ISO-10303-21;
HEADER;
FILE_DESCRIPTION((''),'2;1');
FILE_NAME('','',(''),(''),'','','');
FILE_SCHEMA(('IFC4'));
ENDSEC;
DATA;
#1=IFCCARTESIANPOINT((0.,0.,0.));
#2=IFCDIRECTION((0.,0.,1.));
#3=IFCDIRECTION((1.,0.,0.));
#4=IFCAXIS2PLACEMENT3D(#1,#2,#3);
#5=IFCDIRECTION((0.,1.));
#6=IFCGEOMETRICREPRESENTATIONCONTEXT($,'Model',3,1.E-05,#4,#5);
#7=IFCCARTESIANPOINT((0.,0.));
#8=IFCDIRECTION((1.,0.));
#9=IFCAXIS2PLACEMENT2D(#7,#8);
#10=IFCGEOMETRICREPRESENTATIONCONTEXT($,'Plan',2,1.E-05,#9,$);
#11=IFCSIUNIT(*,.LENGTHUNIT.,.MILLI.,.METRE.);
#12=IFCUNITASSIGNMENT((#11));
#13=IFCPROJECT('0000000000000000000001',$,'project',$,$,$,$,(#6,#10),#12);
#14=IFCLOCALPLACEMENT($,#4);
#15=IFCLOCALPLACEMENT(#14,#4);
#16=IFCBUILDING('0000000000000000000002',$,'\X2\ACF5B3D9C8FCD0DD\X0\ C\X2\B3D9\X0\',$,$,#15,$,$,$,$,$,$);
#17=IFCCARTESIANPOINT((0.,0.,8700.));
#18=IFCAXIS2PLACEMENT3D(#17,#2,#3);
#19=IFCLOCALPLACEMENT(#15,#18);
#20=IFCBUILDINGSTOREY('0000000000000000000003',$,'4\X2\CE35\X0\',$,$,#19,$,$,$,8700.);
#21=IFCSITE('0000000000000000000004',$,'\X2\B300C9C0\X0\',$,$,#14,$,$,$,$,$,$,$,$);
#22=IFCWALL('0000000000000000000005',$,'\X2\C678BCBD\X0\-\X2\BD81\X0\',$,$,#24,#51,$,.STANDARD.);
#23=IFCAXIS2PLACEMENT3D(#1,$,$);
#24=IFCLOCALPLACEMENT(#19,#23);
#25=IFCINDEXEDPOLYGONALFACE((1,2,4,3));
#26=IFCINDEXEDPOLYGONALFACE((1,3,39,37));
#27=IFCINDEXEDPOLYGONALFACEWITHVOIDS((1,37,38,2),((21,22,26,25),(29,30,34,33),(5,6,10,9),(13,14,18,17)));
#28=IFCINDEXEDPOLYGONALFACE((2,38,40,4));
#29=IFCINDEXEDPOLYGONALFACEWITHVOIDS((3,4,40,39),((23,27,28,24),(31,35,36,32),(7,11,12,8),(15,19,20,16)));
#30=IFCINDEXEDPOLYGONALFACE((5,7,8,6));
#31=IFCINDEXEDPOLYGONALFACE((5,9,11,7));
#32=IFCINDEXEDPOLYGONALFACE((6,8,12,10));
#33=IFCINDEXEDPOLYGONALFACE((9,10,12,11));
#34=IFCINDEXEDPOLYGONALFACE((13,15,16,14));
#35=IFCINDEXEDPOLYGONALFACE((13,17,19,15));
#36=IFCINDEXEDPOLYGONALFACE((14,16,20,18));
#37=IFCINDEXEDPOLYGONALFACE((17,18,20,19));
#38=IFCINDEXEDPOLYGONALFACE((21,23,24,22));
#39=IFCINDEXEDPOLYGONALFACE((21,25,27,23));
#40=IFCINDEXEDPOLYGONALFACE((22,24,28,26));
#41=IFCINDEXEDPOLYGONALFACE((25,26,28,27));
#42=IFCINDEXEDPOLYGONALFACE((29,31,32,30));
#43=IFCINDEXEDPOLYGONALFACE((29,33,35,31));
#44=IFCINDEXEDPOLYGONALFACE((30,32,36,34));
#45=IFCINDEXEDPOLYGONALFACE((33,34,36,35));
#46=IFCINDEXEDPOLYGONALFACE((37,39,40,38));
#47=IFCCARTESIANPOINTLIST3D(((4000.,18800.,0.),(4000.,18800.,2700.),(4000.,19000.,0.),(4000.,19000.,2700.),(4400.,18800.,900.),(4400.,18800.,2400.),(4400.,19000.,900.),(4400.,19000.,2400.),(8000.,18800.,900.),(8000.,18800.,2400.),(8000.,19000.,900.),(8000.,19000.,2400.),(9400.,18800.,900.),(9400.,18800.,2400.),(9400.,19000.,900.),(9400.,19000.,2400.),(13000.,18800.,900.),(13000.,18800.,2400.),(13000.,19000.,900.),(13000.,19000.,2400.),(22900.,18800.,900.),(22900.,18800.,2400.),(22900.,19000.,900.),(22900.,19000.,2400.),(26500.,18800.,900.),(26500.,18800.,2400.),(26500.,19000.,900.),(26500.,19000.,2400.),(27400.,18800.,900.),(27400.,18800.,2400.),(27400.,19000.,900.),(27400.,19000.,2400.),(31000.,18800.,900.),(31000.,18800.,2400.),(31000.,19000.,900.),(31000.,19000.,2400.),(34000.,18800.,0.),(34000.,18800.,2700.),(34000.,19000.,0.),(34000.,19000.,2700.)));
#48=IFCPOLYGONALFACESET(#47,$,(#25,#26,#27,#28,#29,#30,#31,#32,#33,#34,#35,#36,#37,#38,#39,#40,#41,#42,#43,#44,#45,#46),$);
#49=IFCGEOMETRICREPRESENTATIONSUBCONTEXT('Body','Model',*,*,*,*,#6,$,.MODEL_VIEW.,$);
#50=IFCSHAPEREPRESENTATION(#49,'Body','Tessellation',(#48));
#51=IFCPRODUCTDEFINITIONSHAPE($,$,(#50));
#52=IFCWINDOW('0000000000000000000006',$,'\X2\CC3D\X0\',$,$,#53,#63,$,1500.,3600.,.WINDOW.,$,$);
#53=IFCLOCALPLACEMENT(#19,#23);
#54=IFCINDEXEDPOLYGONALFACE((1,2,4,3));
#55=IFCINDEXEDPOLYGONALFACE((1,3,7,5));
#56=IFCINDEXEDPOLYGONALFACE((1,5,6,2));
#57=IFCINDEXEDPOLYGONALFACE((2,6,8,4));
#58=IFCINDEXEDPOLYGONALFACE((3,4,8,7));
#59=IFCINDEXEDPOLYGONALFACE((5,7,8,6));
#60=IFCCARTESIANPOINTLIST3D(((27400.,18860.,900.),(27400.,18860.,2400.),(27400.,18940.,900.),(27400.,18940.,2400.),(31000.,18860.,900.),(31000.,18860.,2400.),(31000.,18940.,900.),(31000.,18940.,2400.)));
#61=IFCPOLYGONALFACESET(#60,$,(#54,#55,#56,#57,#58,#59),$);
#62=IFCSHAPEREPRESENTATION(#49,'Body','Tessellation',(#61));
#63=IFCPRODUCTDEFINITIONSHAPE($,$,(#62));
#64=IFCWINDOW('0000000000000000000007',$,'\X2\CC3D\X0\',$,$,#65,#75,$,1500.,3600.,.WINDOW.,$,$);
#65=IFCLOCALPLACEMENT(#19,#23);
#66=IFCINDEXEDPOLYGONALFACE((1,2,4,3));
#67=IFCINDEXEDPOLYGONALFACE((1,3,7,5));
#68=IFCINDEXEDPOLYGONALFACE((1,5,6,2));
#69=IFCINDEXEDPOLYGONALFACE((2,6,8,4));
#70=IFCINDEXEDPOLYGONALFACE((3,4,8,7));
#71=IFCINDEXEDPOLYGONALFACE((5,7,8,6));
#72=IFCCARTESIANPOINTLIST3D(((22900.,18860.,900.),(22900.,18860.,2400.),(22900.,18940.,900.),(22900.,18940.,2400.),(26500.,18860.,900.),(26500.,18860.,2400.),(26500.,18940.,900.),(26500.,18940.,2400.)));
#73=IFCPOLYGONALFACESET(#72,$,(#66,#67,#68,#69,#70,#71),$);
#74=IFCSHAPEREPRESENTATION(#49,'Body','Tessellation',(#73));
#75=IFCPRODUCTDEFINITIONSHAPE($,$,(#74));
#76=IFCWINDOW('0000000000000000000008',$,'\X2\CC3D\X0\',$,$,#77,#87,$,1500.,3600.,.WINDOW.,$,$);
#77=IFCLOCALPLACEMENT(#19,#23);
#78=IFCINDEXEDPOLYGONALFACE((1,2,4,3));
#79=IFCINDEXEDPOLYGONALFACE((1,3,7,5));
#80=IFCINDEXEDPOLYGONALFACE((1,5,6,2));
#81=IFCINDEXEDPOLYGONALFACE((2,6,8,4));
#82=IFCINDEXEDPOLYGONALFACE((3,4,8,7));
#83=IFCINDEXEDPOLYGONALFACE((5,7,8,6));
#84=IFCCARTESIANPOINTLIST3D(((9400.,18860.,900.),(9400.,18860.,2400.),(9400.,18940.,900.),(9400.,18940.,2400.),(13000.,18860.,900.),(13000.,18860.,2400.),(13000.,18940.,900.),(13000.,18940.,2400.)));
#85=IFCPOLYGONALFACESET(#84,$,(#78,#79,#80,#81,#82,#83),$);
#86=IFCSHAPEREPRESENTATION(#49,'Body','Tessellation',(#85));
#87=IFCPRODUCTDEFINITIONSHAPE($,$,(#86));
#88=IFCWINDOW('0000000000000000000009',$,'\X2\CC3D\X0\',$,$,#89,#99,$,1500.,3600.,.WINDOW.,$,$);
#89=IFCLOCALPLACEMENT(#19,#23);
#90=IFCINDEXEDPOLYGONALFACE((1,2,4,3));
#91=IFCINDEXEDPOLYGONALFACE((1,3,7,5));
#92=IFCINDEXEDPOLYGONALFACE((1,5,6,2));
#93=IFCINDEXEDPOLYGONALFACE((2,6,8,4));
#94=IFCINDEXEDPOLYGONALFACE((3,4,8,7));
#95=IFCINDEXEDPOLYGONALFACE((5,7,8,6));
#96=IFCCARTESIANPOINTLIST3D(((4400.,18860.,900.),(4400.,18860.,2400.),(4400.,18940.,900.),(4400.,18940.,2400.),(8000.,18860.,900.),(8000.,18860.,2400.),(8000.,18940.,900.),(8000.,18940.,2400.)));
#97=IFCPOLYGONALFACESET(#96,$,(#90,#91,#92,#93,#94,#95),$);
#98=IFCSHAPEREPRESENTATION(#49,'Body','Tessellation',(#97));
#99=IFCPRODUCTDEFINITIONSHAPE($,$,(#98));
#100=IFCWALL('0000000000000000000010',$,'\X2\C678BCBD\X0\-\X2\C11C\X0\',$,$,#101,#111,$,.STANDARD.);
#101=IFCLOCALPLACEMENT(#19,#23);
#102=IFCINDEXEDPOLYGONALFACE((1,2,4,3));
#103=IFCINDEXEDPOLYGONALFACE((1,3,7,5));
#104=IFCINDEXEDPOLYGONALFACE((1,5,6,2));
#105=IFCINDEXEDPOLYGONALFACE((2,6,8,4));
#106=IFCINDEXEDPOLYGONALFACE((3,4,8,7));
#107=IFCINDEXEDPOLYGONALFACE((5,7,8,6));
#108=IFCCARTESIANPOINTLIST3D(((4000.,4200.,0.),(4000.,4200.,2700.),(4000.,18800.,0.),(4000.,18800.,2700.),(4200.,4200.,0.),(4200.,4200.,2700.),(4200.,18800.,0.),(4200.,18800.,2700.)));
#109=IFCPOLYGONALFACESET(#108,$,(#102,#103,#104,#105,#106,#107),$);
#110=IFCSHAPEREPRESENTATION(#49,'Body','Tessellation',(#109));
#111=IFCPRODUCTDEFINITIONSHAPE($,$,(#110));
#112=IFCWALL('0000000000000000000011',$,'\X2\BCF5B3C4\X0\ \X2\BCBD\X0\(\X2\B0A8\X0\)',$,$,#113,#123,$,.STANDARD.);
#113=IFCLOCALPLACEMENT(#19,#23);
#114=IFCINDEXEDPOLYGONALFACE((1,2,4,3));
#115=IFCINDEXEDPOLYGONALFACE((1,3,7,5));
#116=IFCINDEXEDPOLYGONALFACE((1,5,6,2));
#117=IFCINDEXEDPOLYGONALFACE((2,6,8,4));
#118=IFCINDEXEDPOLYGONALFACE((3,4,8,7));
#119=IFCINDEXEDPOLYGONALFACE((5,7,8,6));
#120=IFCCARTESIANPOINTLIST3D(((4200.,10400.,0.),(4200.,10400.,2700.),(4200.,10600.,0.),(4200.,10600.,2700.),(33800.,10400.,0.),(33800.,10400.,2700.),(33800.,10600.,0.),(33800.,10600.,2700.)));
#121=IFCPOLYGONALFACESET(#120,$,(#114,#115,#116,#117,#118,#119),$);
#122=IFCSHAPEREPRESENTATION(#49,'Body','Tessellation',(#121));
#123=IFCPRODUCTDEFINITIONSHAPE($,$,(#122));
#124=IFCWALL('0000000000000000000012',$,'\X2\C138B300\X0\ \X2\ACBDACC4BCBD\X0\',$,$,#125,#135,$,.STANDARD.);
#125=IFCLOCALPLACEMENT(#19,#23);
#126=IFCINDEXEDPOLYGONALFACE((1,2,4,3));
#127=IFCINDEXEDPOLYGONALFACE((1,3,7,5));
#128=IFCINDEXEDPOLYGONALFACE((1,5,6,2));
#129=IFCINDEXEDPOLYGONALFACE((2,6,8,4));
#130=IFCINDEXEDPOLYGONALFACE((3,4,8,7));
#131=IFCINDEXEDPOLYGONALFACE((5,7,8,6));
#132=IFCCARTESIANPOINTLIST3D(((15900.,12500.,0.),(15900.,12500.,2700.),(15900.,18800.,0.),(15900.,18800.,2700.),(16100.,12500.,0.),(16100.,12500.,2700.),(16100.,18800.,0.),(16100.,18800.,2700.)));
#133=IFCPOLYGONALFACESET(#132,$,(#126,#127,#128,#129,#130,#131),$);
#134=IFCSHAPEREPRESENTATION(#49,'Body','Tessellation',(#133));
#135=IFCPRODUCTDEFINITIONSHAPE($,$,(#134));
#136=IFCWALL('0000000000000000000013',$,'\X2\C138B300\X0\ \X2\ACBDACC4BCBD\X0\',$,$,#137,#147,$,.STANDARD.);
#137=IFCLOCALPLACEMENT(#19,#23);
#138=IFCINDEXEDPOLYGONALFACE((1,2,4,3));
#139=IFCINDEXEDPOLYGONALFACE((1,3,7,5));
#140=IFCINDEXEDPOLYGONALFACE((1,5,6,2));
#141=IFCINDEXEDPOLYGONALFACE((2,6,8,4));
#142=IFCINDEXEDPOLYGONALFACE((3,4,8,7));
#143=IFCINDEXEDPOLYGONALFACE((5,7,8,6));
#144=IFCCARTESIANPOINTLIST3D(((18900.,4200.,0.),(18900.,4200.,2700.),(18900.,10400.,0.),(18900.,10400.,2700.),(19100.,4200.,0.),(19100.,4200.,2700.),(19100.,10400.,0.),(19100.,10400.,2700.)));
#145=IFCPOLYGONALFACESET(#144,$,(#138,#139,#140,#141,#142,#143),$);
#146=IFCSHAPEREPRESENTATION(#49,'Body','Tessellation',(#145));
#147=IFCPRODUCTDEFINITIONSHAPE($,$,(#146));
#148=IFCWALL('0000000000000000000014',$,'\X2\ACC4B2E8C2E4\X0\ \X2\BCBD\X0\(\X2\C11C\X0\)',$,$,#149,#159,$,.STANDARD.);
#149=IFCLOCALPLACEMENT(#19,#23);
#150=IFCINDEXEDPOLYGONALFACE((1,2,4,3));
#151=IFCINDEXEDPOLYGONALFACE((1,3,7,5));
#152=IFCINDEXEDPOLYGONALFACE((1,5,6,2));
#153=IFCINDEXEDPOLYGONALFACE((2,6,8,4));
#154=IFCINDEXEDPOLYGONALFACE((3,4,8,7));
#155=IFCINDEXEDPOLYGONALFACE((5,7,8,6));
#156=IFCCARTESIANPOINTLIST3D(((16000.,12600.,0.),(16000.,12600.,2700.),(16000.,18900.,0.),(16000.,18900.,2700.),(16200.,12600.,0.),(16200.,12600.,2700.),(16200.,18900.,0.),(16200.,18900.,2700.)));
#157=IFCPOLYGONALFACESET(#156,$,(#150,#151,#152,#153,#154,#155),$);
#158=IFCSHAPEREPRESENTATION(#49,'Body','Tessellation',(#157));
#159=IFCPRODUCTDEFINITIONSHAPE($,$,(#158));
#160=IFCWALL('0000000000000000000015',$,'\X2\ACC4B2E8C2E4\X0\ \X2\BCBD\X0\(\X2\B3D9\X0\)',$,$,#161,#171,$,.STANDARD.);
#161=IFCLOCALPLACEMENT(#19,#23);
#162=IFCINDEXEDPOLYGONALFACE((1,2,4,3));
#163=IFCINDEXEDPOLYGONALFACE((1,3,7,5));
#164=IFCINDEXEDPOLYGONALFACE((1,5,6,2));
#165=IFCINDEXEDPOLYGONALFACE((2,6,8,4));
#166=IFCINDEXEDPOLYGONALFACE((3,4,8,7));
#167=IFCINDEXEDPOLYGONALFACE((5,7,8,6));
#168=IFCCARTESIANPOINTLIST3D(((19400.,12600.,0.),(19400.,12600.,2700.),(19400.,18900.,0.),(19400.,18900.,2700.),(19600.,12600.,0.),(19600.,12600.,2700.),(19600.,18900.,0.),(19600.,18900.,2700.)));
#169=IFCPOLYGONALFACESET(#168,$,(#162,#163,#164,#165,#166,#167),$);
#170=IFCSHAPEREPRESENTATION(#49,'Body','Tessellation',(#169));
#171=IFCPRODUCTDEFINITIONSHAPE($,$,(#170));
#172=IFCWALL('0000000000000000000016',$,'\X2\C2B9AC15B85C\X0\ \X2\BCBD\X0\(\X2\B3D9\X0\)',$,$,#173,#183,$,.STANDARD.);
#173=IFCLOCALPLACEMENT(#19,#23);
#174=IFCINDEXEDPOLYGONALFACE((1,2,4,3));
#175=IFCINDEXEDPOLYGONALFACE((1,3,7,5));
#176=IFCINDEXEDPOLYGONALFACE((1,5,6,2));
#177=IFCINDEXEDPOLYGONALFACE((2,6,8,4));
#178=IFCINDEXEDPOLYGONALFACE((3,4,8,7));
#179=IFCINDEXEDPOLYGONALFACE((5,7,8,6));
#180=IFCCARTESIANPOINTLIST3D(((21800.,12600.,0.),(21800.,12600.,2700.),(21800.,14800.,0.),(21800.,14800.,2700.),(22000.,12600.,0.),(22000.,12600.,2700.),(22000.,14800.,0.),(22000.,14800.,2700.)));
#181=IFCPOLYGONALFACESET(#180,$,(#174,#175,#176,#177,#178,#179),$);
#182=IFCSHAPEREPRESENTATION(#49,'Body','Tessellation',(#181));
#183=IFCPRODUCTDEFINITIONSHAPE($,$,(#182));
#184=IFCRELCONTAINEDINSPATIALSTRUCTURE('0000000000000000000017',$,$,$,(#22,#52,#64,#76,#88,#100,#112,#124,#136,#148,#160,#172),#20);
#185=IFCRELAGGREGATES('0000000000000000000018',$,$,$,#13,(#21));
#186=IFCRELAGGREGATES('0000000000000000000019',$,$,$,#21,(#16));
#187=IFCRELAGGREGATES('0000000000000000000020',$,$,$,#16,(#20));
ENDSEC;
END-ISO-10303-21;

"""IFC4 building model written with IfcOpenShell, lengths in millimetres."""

from ifc_helpers import new_model, si_unit, direction, frame, origin_with_axes, origin_2d_with_axis, place, context, subcontext, project, spatial, polyline, outline, extrude, element, fill, save


model = new_model("IFC4")

# Units and contexts
model_context = context("Model", 3, precision=1e-05, world=origin_with_axes(), true_north=direction((0.0, 1.0)))
plan_context = context("Plan", 2, precision=1e-05, world=origin_2d_with_axis())
body_context = subcontext(model_context, "Body", "Model", "MODEL_VIEW")
ifc_project = project(units=[si_unit("LENGTHUNIT", "METRE", prefix="MILLI")], contexts=[model_context, plan_context])

# Site, building, storey
site_placement = place(None, origin_with_axes())
site = spatial("IfcSite", under=ifc_project, at=site_placement, Name="대지")
building_placement = place(site_placement, origin_with_axes())
building = spatial("IfcBuilding", under=site, at=building_placement, Name="공동주택 C동")
storey_placement = place(building_placement, frame((0.0, 0.0, 8700.0), z_axis=(0.0, 0.0, 1.0), x_axis=(1.0, 0.0, 0.0)))
storey = spatial("IfcBuildingStorey", under=building, at=storey_placement, Name="4층", Elevation=8700.0)

# Wall, openings, windows
wall_1_placement = place(storey_placement, origin_with_axes())
wall_1 = element("IfcWall", 1, at=wall_1_placement, inside=storey, Name="외벽-북", PredefinedType="STANDARD", context=body_context, shape_type="SweptSolid", body=[
    extrude(outline(polyline([(34000.0, 18800.0), (4000.0, 18800.0), (4000.0, 19000.0), (34000.0, 19000.0), (34000.0, 18800.0)])), origin_with_axes(), (0.0, 0.0, 1.0), 2700.0),
])
opening_1_placement = place(storey_placement, origin_with_axes())
opening_1 = element("IfcOpeningElement", 2, at=opening_1_placement, cuts=wall_1, PredefinedType="OPENING", context=body_context, shape_type="SweptSolid", body=[
    extrude(outline(polyline([(31000.0, 19050.0), (27400.0, 19050.0), (27400.0, 18750.0), (31000.0, 18750.0), (31000.0, 19050.0)])), frame((0.0, 0.0, 900.0), z_axis=(0.0, 0.0, 1.0), x_axis=(1.0, 0.0, 0.0)), (0.0, 0.0, 1.0), 1500.0),
])
opening_2_placement = place(storey_placement, origin_with_axes())
opening_2 = element("IfcOpeningElement", 3, at=opening_2_placement, cuts=wall_1, PredefinedType="OPENING", context=body_context, shape_type="SweptSolid", body=[
    extrude(outline(polyline([(26500.0, 19050.0), (22900.0, 19050.0), (22900.0, 18750.0), (26500.0, 18750.0), (26500.0, 19050.0)])), frame((0.0, 0.0, 900.0), z_axis=(0.0, 0.0, 1.0), x_axis=(1.0, 0.0, 0.0)), (0.0, 0.0, 1.0), 1500.0),
])
opening_3_placement = place(storey_placement, origin_with_axes())
opening_3 = element("IfcOpeningElement", 4, at=opening_3_placement, cuts=wall_1, PredefinedType="OPENING", context=body_context, shape_type="SweptSolid", body=[
    extrude(outline(polyline([(13000.0, 19050.0), (9400.0, 19050.0), (9400.0, 18750.0), (13000.0, 18750.0), (13000.0, 19050.0)])), frame((0.0, 0.0, 900.0), z_axis=(0.0, 0.0, 1.0), x_axis=(1.0, 0.0, 0.0)), (0.0, 0.0, 1.0), 1500.0),
])
opening_4_placement = place(storey_placement, origin_with_axes())
opening_4 = element("IfcOpeningElement", 5, at=opening_4_placement, cuts=wall_1, PredefinedType="OPENING", context=body_context, shape_type="SweptSolid", body=[
    extrude(outline(polyline([(8000.0, 19050.0), (4400.0, 19050.0), (4400.0, 18750.0), (8000.0, 18750.0), (8000.0, 19050.0)])), frame((0.0, 0.0, 900.0), z_axis=(0.0, 0.0, 1.0), x_axis=(1.0, 0.0, 0.0)), (0.0, 0.0, 1.0), 1500.0),
])
window_1_placement = place(storey_placement, origin_with_axes())
window_1 = element("IfcWindow", 6, at=window_1_placement, inside=storey, Name="창", OverallHeight=1500.0, OverallWidth=3600.0, PredefinedType="WINDOW", context=body_context, shape_type="SweptSolid", body=[
    extrude(outline(polyline([(31000.0, 18940.0), (27400.0, 18940.0), (27400.0, 18860.0), (31000.0, 18860.0), (31000.0, 18940.0)])), frame((0.0, 0.0, 900.0), z_axis=(0.0, 0.0, 1.0), x_axis=(1.0, 0.0, 0.0)), (0.0, 0.0, 1.0), 1500.0),
])
fill(opening_1, window_1)
window_2_placement = place(storey_placement, origin_with_axes())
window_2 = element("IfcWindow", 7, at=window_2_placement, inside=storey, Name="창", OverallHeight=1500.0, OverallWidth=3600.0, PredefinedType="WINDOW", context=body_context, shape_type="SweptSolid", body=[
    extrude(outline(polyline([(26500.0, 18940.0), (22900.0, 18940.0), (22900.0, 18860.0), (26500.0, 18860.0), (26500.0, 18940.0)])), frame((0.0, 0.0, 900.0), z_axis=(0.0, 0.0, 1.0), x_axis=(1.0, 0.0, 0.0)), (0.0, 0.0, 1.0), 1500.0),
])
fill(opening_2, window_2)
window_3_placement = place(storey_placement, origin_with_axes())
window_3 = element("IfcWindow", 8, at=window_3_placement, inside=storey, Name="창", OverallHeight=1500.0, OverallWidth=3600.0, PredefinedType="WINDOW", context=body_context, shape_type="SweptSolid", body=[
    extrude(outline(polyline([(13000.0, 18940.0), (9400.0, 18940.0), (9400.0, 18860.0), (13000.0, 18860.0), (13000.0, 18940.0)])), frame((0.0, 0.0, 900.0), z_axis=(0.0, 0.0, 1.0), x_axis=(1.0, 0.0, 0.0)), (0.0, 0.0, 1.0), 1500.0),
])
fill(opening_3, window_3)
window_4_placement = place(storey_placement, origin_with_axes())
window_4 = element("IfcWindow", 9, at=window_4_placement, inside=storey, Name="창", OverallHeight=1500.0, OverallWidth=3600.0, PredefinedType="WINDOW", context=body_context, shape_type="SweptSolid", body=[
    extrude(outline(polyline([(8000.0, 18940.0), (4400.0, 18940.0), (4400.0, 18860.0), (8000.0, 18860.0), (8000.0, 18940.0)])), frame((0.0, 0.0, 900.0), z_axis=(0.0, 0.0, 1.0), x_axis=(1.0, 0.0, 0.0)), (0.0, 0.0, 1.0), 1500.0),
])
fill(opening_4, window_4)

# Walls
wall_2_placement = place(storey_placement, origin_with_axes())
element("IfcWall", 10, at=wall_2_placement, inside=storey, Name="외벽-서", PredefinedType="STANDARD", context=body_context, shape_type="SweptSolid", body=[
    extrude(outline(polyline([(4200.0, 18800.0), (4200.0, 4200.0), (4000.0, 4200.0), (4000.0, 18800.0), (4200.0, 18800.0)])), origin_with_axes(), (0.0, 0.0, 1.0), 2700.0),
])
wall_3_placement = place(storey_placement, origin_with_axes())
element("IfcWall", 11, at=wall_3_placement, inside=storey, Name="복도 벽(남)", PredefinedType="STANDARD", context=body_context, shape_type="SweptSolid", body=[
    extrude(outline(polyline([(4200.0, 10600.0), (33800.0, 10600.0), (33800.0, 10400.0), (4200.0, 10400.0), (4200.0, 10600.0)])), origin_with_axes(), (0.0, 0.0, 1.0), 2700.0),
])
wall_4_placement = place(storey_placement, origin_with_axes())
element("IfcWall", 12, at=wall_4_placement, inside=storey, Name="세대 경계벽", PredefinedType="STANDARD", context=body_context, shape_type="SweptSolid", body=[
    extrude(outline(polyline([(15900.0, 12500.0), (15900.0, 18800.0), (16100.0, 18800.0), (16100.0, 12500.0), (15900.0, 12500.0)])), origin_with_axes(), (0.0, 0.0, 1.0), 2700.0),
])
wall_5_placement = place(storey_placement, origin_with_axes())
element("IfcWall", 13, at=wall_5_placement, inside=storey, Name="세대 경계벽", PredefinedType="STANDARD", context=body_context, shape_type="SweptSolid", body=[
    extrude(outline(polyline([(18900.0, 4200.0), (18900.0, 10400.0), (19100.0, 10400.0), (19100.0, 4200.0), (18900.0, 4200.0)])), origin_with_axes(), (0.0, 0.0, 1.0), 2700.0),
])
wall_6_placement = place(storey_placement, origin_with_axes())
element("IfcWall", 14, at=wall_6_placement, inside=storey, Name="계단실 벽(서)", PredefinedType="STANDARD", context=body_context, shape_type="SweptSolid", body=[
    extrude(outline(polyline([(16000.0, 12600.0), (16000.0, 18900.0), (16200.0, 18900.0), (16200.0, 12600.0), (16000.0, 12600.0)])), origin_with_axes(), (0.0, 0.0, 1.0), 2700.0),
])
wall_7_placement = place(storey_placement, origin_with_axes())
element("IfcWall", 15, at=wall_7_placement, inside=storey, Name="계단실 벽(동)", PredefinedType="STANDARD", context=body_context, shape_type="SweptSolid", body=[
    extrude(outline(polyline([(19400.0, 12600.0), (19400.0, 18900.0), (19600.0, 18900.0), (19600.0, 12600.0), (19400.0, 12600.0)])), origin_with_axes(), (0.0, 0.0, 1.0), 2700.0),
])
wall_8_placement = place(storey_placement, origin_with_axes())
element("IfcWall", 16, at=wall_8_placement, inside=storey, Name="승강로 벽(동)", PredefinedType="STANDARD", context=body_context, shape_type="SweptSolid", body=[
    extrude(outline(polyline([(21800.0, 12600.0), (21800.0, 14800.0), (22000.0, 14800.0), (22000.0, 12600.0), (21800.0, 12600.0)])), origin_with_axes(), (0.0, 0.0, 1.0), 2700.0),
])

save(model, "model.ifc")
